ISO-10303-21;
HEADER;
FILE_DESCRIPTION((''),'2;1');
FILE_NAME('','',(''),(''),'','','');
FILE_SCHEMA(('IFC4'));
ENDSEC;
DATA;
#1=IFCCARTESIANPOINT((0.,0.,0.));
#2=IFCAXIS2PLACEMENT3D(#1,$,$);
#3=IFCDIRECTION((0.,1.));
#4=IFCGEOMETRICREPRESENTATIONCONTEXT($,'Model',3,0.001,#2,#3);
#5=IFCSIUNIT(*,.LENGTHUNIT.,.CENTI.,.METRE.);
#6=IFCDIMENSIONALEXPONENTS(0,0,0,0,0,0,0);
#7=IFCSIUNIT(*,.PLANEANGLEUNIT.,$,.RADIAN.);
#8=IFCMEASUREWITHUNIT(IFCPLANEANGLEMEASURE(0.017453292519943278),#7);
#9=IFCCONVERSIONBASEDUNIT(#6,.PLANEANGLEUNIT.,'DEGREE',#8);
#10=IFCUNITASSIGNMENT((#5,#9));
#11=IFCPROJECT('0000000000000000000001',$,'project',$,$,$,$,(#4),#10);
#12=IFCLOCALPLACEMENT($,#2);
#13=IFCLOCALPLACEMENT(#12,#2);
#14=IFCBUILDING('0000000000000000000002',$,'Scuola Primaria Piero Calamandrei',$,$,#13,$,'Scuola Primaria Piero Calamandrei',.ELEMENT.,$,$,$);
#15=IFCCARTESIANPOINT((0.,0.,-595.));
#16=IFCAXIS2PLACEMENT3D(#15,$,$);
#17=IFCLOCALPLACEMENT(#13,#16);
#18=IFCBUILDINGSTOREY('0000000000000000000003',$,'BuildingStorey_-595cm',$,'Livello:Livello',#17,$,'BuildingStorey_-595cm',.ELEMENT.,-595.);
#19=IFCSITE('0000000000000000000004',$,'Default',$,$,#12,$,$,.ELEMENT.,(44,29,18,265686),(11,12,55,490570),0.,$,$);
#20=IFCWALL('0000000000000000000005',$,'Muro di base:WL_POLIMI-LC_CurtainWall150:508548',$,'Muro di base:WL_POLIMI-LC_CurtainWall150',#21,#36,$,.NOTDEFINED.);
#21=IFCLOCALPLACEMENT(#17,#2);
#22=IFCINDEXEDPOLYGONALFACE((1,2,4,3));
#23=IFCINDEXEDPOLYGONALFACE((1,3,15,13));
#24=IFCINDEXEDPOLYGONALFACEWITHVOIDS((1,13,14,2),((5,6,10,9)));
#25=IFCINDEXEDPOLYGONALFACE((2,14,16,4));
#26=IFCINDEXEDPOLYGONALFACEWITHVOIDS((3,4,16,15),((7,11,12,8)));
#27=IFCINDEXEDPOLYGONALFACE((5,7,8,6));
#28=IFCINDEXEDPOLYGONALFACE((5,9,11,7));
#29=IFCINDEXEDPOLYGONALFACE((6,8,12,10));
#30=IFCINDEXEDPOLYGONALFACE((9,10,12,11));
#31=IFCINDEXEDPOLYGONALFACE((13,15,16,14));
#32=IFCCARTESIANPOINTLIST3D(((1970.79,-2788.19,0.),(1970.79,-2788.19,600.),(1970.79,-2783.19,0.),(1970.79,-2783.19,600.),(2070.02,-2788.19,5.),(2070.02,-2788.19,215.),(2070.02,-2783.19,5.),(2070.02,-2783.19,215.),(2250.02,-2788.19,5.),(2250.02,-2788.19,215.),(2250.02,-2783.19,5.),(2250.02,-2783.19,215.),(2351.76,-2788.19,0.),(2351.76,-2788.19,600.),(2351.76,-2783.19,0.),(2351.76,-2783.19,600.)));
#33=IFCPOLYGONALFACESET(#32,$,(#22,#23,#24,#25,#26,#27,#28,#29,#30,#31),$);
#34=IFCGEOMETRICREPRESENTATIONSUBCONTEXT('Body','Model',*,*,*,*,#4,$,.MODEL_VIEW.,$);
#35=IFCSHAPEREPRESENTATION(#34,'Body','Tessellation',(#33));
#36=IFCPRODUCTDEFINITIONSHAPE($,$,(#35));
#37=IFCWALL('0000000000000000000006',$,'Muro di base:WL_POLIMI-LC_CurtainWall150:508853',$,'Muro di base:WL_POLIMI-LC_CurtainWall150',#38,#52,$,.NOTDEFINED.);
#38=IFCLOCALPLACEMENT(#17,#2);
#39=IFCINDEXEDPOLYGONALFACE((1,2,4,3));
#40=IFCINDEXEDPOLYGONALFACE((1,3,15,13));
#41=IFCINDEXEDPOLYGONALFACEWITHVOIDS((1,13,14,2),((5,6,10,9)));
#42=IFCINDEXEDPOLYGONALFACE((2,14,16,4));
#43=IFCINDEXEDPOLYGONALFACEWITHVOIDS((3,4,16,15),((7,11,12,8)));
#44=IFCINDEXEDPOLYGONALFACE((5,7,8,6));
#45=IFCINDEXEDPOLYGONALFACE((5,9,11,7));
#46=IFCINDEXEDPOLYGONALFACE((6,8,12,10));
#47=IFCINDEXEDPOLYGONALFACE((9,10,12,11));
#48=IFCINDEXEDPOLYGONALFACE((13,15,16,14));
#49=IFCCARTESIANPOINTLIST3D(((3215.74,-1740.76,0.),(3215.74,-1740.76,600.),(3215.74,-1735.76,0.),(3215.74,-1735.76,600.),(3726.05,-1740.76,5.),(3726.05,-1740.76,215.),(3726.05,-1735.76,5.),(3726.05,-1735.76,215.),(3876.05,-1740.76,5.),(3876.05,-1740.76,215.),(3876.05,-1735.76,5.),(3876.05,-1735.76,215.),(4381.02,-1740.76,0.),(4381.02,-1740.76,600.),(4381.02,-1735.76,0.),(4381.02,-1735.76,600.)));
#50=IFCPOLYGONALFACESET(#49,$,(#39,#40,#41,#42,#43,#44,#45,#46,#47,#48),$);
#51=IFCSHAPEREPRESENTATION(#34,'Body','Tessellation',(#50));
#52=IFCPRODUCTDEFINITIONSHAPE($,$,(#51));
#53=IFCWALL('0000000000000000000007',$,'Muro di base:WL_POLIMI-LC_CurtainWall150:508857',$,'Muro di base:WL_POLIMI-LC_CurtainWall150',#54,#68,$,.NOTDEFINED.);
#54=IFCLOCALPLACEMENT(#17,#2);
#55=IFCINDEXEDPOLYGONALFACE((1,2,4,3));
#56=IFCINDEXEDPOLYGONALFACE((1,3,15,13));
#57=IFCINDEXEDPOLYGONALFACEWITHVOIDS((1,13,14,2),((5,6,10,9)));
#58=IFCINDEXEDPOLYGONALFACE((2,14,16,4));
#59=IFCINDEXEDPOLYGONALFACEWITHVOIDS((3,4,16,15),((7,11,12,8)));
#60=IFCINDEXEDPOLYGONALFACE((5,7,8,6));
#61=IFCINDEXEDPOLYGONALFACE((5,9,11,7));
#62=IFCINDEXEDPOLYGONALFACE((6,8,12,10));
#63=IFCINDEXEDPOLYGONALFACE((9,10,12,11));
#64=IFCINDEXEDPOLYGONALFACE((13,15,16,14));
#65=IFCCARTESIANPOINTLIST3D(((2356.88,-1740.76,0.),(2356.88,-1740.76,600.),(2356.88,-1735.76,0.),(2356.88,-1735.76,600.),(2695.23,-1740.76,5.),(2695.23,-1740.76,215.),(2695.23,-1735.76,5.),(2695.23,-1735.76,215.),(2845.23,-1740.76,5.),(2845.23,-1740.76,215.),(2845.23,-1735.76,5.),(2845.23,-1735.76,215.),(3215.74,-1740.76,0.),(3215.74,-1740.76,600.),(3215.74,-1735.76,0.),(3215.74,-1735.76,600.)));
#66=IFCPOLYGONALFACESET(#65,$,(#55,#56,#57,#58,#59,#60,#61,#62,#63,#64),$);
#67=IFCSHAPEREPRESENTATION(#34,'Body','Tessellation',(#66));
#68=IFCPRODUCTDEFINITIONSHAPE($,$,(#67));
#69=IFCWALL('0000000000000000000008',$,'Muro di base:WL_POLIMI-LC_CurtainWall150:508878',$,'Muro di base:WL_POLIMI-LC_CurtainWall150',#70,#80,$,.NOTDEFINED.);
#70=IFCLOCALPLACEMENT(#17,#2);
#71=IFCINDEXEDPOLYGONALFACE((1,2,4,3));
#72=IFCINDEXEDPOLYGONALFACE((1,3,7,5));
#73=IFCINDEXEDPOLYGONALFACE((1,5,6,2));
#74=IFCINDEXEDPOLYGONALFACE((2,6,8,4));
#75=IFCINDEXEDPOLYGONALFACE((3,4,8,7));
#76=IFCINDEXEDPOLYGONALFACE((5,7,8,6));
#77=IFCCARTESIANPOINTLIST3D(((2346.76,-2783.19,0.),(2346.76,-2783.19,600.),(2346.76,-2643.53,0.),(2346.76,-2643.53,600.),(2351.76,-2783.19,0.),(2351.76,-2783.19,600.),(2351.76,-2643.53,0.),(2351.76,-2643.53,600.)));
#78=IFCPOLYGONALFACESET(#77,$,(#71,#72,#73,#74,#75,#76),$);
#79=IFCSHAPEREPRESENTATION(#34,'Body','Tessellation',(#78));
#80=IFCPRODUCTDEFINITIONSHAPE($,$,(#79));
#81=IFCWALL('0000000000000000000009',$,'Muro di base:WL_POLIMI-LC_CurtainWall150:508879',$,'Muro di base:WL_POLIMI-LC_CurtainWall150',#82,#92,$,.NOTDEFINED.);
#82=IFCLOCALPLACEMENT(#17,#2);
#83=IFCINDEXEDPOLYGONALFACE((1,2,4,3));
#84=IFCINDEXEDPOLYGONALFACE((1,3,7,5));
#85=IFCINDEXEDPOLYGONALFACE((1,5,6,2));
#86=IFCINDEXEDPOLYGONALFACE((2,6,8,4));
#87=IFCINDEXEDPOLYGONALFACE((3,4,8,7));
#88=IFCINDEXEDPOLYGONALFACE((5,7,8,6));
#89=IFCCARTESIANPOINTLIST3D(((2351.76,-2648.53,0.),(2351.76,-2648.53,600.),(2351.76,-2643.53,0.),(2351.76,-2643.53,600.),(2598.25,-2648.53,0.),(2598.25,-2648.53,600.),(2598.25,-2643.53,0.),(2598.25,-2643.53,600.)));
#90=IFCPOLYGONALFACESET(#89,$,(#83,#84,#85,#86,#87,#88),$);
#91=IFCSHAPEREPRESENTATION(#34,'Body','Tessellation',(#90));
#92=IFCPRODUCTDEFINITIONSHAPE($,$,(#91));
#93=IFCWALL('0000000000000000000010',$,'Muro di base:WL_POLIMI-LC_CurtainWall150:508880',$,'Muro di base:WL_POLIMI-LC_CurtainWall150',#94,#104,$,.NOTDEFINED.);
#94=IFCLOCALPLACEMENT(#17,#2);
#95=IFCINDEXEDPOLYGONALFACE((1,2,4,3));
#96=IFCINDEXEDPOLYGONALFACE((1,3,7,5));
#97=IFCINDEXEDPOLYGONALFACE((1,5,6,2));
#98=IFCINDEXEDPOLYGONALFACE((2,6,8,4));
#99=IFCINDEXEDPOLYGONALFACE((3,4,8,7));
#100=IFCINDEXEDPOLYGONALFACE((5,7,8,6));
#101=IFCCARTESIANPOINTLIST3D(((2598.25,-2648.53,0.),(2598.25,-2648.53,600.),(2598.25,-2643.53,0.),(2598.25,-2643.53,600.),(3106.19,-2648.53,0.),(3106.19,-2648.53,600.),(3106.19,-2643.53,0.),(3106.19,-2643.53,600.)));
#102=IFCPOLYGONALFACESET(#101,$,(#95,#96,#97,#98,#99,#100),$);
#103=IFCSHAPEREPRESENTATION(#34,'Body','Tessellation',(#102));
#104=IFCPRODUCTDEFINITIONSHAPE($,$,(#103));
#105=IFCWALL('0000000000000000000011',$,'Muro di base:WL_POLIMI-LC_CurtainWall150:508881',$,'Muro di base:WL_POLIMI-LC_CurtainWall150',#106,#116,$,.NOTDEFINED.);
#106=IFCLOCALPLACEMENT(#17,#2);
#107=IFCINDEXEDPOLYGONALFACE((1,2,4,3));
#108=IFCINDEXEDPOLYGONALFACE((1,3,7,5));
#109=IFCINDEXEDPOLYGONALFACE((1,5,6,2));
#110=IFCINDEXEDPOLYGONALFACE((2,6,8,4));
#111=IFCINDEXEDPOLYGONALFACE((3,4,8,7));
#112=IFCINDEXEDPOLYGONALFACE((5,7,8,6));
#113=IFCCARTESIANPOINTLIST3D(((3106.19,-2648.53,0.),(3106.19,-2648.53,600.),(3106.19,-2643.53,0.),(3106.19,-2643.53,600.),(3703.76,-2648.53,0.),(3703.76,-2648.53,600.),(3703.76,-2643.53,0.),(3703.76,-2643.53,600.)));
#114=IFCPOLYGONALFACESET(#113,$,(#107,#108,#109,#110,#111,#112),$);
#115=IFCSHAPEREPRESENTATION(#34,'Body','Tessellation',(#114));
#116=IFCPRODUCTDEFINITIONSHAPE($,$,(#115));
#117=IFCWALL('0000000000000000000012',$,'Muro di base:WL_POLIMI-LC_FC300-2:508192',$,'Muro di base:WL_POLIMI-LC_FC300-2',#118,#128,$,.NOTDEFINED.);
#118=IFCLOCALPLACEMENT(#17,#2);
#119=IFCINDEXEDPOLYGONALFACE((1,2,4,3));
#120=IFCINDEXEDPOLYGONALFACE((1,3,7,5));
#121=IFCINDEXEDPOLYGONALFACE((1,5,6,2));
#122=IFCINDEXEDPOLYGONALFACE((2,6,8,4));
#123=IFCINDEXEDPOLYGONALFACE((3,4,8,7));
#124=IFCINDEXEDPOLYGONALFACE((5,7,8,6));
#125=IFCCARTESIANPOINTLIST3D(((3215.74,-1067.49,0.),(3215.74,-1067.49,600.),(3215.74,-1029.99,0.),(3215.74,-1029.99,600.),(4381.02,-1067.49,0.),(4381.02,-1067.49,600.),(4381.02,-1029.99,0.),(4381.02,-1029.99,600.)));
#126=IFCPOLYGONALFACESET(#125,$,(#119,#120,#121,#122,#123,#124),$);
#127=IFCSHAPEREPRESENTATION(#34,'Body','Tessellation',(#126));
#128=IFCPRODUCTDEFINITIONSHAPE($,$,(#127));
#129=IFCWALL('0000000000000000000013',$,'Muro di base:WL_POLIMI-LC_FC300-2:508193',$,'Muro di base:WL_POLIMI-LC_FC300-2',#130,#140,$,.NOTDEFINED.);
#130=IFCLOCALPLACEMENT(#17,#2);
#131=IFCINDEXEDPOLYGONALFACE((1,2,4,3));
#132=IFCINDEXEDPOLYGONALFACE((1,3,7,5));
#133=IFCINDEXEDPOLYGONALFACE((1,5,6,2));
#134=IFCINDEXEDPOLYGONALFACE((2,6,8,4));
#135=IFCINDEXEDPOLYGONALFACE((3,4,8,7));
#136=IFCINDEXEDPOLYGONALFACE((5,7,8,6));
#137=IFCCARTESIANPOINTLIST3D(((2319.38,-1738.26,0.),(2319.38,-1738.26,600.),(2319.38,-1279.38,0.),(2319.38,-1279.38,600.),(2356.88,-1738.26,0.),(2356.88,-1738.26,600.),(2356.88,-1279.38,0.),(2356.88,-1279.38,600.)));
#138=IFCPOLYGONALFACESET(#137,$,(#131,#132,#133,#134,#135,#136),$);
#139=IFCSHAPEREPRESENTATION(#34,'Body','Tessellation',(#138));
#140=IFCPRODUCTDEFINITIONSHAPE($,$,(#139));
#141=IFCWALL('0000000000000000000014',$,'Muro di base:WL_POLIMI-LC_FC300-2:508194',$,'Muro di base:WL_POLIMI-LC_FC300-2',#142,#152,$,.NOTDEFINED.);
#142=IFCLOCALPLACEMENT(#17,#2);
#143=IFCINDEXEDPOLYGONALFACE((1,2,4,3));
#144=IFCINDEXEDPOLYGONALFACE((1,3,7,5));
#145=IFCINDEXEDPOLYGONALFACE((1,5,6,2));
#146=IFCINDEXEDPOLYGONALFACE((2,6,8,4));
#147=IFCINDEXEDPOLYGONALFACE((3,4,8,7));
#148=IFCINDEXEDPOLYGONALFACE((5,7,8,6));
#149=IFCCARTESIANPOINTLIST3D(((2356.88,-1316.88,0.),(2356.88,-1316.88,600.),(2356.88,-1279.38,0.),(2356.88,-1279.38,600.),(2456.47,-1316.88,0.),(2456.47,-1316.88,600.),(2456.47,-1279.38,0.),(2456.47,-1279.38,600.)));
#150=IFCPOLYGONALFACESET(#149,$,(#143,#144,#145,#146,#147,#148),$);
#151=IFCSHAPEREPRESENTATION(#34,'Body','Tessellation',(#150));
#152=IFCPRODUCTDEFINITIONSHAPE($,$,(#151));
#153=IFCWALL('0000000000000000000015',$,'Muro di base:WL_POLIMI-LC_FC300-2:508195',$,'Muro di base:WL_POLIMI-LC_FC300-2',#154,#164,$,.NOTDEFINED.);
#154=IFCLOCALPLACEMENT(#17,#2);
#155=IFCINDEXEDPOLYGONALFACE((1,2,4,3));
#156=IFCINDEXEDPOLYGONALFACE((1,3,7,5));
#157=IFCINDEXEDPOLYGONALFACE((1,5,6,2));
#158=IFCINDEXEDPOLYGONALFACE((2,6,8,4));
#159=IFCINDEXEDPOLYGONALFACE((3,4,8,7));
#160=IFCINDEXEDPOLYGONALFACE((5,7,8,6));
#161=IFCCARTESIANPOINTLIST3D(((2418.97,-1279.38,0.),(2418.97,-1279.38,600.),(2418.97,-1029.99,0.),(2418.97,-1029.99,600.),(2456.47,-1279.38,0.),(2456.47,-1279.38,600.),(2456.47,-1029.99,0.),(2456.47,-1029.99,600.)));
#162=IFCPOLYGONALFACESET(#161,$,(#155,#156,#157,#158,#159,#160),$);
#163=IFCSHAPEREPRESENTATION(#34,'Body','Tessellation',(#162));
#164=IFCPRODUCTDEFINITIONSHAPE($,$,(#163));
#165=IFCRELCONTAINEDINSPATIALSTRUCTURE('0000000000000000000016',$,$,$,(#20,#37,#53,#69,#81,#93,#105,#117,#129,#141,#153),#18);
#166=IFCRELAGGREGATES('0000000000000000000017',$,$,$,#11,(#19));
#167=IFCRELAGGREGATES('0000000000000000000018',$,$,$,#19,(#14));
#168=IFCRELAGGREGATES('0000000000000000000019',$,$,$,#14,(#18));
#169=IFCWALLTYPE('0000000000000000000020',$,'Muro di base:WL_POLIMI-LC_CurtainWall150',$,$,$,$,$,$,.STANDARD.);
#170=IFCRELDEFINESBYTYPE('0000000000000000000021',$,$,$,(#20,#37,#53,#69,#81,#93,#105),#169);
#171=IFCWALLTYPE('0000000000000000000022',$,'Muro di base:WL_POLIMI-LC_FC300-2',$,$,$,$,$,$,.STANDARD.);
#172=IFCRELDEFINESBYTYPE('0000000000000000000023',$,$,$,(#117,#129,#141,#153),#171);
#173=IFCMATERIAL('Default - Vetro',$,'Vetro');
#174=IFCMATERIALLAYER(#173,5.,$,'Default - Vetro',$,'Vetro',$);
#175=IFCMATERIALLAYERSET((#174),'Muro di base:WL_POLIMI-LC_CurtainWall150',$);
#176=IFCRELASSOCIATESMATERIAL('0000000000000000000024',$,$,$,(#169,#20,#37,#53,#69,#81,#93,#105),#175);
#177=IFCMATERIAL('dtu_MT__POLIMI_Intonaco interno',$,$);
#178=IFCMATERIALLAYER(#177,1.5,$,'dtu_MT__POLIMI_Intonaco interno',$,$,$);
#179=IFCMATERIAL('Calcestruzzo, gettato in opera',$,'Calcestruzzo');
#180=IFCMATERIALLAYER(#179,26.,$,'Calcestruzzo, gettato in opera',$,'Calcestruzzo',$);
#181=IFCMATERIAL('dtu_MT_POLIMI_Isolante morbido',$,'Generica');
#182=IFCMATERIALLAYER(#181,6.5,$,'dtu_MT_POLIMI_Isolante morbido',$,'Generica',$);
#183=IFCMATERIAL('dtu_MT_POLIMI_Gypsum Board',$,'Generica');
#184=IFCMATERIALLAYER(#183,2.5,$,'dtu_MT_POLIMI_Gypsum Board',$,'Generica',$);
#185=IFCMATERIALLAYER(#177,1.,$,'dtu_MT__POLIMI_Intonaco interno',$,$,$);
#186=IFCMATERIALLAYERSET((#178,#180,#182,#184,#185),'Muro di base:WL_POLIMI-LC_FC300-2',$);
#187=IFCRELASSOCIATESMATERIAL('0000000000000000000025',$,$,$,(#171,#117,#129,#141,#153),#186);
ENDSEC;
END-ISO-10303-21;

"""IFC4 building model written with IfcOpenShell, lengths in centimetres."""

from ifc_helpers import new_model, entity, si_unit, converted_unit, direction, frame, frame_2d, origin, place, context, subcontext, project, spatial, rectangle, extrude, material, layer, layer_set, layer_usage, type_object, element, save


model = new_model("IFC4")

# Units and contexts
model_context = context("Model", 3, precision=0.001, world=origin(), true_north=direction((0.0, 1.0)))
body_context = subcontext(model_context, "Body", "Model", "MODEL_VIEW")
ifc_project = project(units=[si_unit("LENGTHUNIT", "METRE", prefix="CENTI"), converted_unit("PLANEANGLEUNIT", "DEGREE", entity("IfcPlaneAngleMeasure", 0.017453292519943278), si_unit("PLANEANGLEUNIT", "RADIAN"), dimensions=[0, 0, 0, 0, 0, 0, 0])], contexts=[model_context])

# Site, building, storey
site_placement = place(None, origin())
site = spatial("IfcSite", under=ifc_project, at=site_placement, Name="Default", CompositionType="ELEMENT", RefLatitude=(44, 29, 18, 265686), RefLongitude=(11, 12, 55, 490570), RefElevation=0.0)
building_placement = place(site_placement, origin())
building = spatial("IfcBuilding", under=site, at=building_placement, Name="Scuola Primaria Piero Calamandrei", LongName="Scuola Primaria Piero Calamandrei", CompositionType="ELEMENT")
storey_placement = place(building_placement, frame((0.0, 0.0, -595.0)))
storey = spatial("IfcBuildingStorey", under=building, at=storey_placement, Name="BuildingStorey_-595cm", ObjectType="Livello:Livello", LongName="BuildingStorey_-595cm", CompositionType="ELEMENT", Elevation=-595.0)

# Wall, opening
ifc_material_1 = material(Name="Default - Vetro", Category="Vetro")
ifc_layer_1 = layer(ifc_material_1, 5.0, Name="Default - Vetro", Category="Vetro")
ifc_layer_set_1 = layer_set([ifc_layer_1], Name="Muro di base:WL_POLIMI-LC_CurtainWall150")
ifc_layer_usage_1 = layer_usage(ifc_layer_set_1, "AXIS2", "NEGATIVE", 2.5)
wall_type_1 = type_object("IfcWallType", Name="Muro di base:WL_POLIMI-LC_CurtainWall150", PredefinedType="STANDARD", material=ifc_layer_set_1)
wall_1_placement = place(storey_placement, frame((1970.79, -2785.69, 0.0)))
wall_1 = element("IfcWall", 1, at=wall_1_placement, inside=storey, type_object=wall_type_1, material=ifc_layer_usage_1, Name="Muro di base:WL_POLIMI-LC_CurtainWall150:508548", ObjectType="Muro di base:WL_POLIMI-LC_CurtainWall150", PredefinedType="NOTDEFINED", context=body_context, shape_type="SweptSolid", body=[
    extrude(rectangle(XDim=380.97, YDim=5.0, at=frame_2d((190.48, 0.0), x_axis=(-1.0, 0.0))), origin(), (0.0, 0.0, 1.0), 600.0),
])
opening_1_placement = place(wall_1_placement, frame((99.23, -2.5, 5.0)))
element("IfcOpeningElement", 2, at=opening_1_placement, cuts=wall_1, PredefinedType="OPENING", context=body_context, shape_type="SweptSolid", body=[
    extrude(rectangle(XDim=210.0, YDim=180.0, at=frame_2d((105.0, 90.0), x_axis=(-1.0, 0.0))), frame((0.0, 0.0, 0.0), z_axis=(0.0, 1.0, 0.0), x_axis=(0.0, 0.0, 1.0)), (0.0, 0.0, 1.0), 5.0),
])

# Walls, openings
ifc_layer_usage_2 = layer_usage(ifc_layer_set_1, "AXIS2", "NEGATIVE", 2.5)
wall_2_placement = place(storey_placement, frame((3215.74, -1738.26, 0.0)))
wall_2 = element("IfcWall", 3, at=wall_2_placement, inside=storey, type_object=wall_type_1, material=ifc_layer_usage_2, Name="Muro di base:WL_POLIMI-LC_CurtainWall150:508853", ObjectType="Muro di base:WL_POLIMI-LC_CurtainWall150", PredefinedType="NOTDEFINED", context=body_context, shape_type="SweptSolid", body=[
    extrude(rectangle(XDim=1165.28, YDim=5.0, at=frame_2d((582.64, 0.0), x_axis=(-1.0, 0.0))), origin(), (0.0, 0.0, 1.0), 600.0),
])
opening_2_placement = place(wall_2_placement, frame((660.31, 2.5, 5.0)))
element("IfcOpeningElement", 4, at=opening_2_placement, cuts=wall_2, PredefinedType="OPENING", context=body_context, shape_type="SweptSolid", body=[
    extrude(rectangle(XDim=210.0, YDim=150.0, at=frame_2d((105.0, 75.0), x_axis=(-1.0, 0.0))), frame((0.0, 0.0, 0.0), z_axis=(0.0, -1.0, 0.0), x_axis=(0.0, 0.0, 1.0)), (0.0, 0.0, 1.0), 5.0),
])
ifc_layer_usage_3 = layer_usage(ifc_layer_set_1, "AXIS2", "NEGATIVE", 2.5)
wall_3_placement = place(storey_placement, frame((2356.88, -1738.26, 0.0)))
wall_3 = element("IfcWall", 5, at=wall_3_placement, inside=storey, type_object=wall_type_1, material=ifc_layer_usage_3, Name="Muro di base:WL_POLIMI-LC_CurtainWall150:508857", ObjectType="Muro di base:WL_POLIMI-LC_CurtainWall150", PredefinedType="NOTDEFINED", context=body_context, shape_type="SweptSolid", body=[
    extrude(rectangle(XDim=858.87, YDim=5.0, at=frame_2d((429.43, 0.0), x_axis=(-1.0, 0.0))), origin(), (0.0, 0.0, 1.0), 600.0),
])
opening_3_placement = place(wall_3_placement, frame((488.36, 2.5, 5.0)))
element("IfcOpeningElement", 6, at=opening_3_placement, cuts=wall_3, PredefinedType="OPENING", context=body_context, shape_type="SweptSolid", body=[
    extrude(rectangle(XDim=210.0, YDim=150.0, at=frame_2d((105.0, 75.0), x_axis=(-1.0, 0.0))), frame((0.0, 0.0, 0.0), z_axis=(0.0, -1.0, 0.0), x_axis=(0.0, 0.0, 1.0)), (0.0, 0.0, 1.0), 5.0),
])

# Walls
ifc_layer_usage_4 = layer_usage(ifc_layer_set_1, "AXIS2", "NEGATIVE", 2.5)
wall_4_placement = place(storey_placement, frame((2349.26, -2643.53, 0.0), z_axis=(0.0, 0.0, 1.0), x_axis=(0.0, -1.0, 0.0)))
element("IfcWall", 7, at=wall_4_placement, inside=storey, type_object=wall_type_1, material=ifc_layer_usage_4, Name="Muro di base:WL_POLIMI-LC_CurtainWall150:508878", ObjectType="Muro di base:WL_POLIMI-LC_CurtainWall150", PredefinedType="NOTDEFINED", context=body_context, shape_type="SweptSolid", body=[
    extrude(rectangle(XDim=139.66, YDim=5.0, at=frame_2d((69.83, 0.0), x_axis=(-1.0, 0.0))), origin(), (0.0, 0.0, 1.0), 600.0),
])
ifc_layer_usage_5 = layer_usage(ifc_layer_set_1, "AXIS2", "NEGATIVE", 2.5)
wall_5_placement = place(storey_placement, frame((2598.25, -2646.03, 0.0), z_axis=(0.0, 0.0, 1.0), x_axis=(-1.0, 0.0, 0.0)))
element("IfcWall", 8, at=wall_5_placement, inside=storey, type_object=wall_type_1, material=ifc_layer_usage_5, Name="Muro di base:WL_POLIMI-LC_CurtainWall150:508879", ObjectType="Muro di base:WL_POLIMI-LC_CurtainWall150", PredefinedType="NOTDEFINED", context=body_context, shape_type="SweptSolid", body=[
    extrude(rectangle(XDim=246.49, YDim=5.0, at=frame_2d((123.25, 0.0), x_axis=(-1.0, 0.0))), origin(), (0.0, 0.0, 1.0), 600.0),
])
ifc_layer_usage_6 = layer_usage(ifc_layer_set_1, "AXIS2", "NEGATIVE", 2.5)
wall_6_placement = place(storey_placement, frame((3106.19, -2646.03, 0.0), z_axis=(0.0, 0.0, 1.0), x_axis=(-1.0, 0.0, 0.0)))
element("IfcWall", 9, at=wall_6_placement, inside=storey, type_object=wall_type_1, material=ifc_layer_usage_6, Name="Muro di base:WL_POLIMI-LC_CurtainWall150:508880", ObjectType="Muro di base:WL_POLIMI-LC_CurtainWall150", PredefinedType="NOTDEFINED", context=body_context, shape_type="SweptSolid", body=[
    extrude(rectangle(XDim=507.94, YDim=5.0, at=frame_2d((253.97, 0.0), x_axis=(-1.0, 0.0))), origin(), (0.0, 0.0, 1.0), 600.0),
])
ifc_layer_usage_7 = layer_usage(ifc_layer_set_1, "AXIS2", "NEGATIVE", 2.5)
wall_7_placement = place(storey_placement, frame((3703.76, -2646.03, 0.0), z_axis=(0.0, 0.0, 1.0), x_axis=(-1.0, 0.0, 0.0)))
element("IfcWall", 10, at=wall_7_placement, inside=storey, type_object=wall_type_1, material=ifc_layer_usage_7, Name="Muro di base:WL_POLIMI-LC_CurtainWall150:508881", ObjectType="Muro di base:WL_POLIMI-LC_CurtainWall150", PredefinedType="NOTDEFINED", context=body_context, shape_type="SweptSolid", body=[
    extrude(rectangle(XDim=597.58, YDim=5.0, at=frame_2d((298.79, 0.0), x_axis=(-1.0, 0.0))), origin(), (0.0, 0.0, 1.0), 600.0),
])
ifc_material_2 = material(Name="dtu_MT__POLIMI_Intonaco interno")
ifc_layer_2 = layer(ifc_material_2, 1.5, Name="dtu_MT__POLIMI_Intonaco interno")
ifc_material_3 = material(Name="Calcestruzzo, gettato in opera", Category="Calcestruzzo")
ifc_layer_3 = layer(ifc_material_3, 26.0, Name="Calcestruzzo, gettato in opera", Category="Calcestruzzo")
ifc_material_4 = material(Name="dtu_MT_POLIMI_Isolante morbido", Category="Generica")
ifc_layer_4 = layer(ifc_material_4, 6.5, Name="dtu_MT_POLIMI_Isolante morbido", Category="Generica")
ifc_material_5 = material(Name="dtu_MT_POLIMI_Gypsum Board", Category="Generica")
ifc_layer_5 = layer(ifc_material_5, 2.5, Name="dtu_MT_POLIMI_Gypsum Board", Category="Generica")
ifc_layer_6 = layer(ifc_material_2, 1.0, Name="dtu_MT__POLIMI_Intonaco interno")
ifc_layer_set_2 = layer_set([ifc_layer_2, ifc_layer_3, ifc_layer_4, ifc_layer_5, ifc_layer_6], Name="Muro di base:WL_POLIMI-LC_FC300-2")
ifc_layer_usage_8 = layer_usage(ifc_layer_set_2, "AXIS2", "NEGATIVE", 18.75)
wall_type_2 = type_object("IfcWallType", Name="Muro di base:WL_POLIMI-LC_FC300-2", PredefinedType="STANDARD", material=ifc_layer_set_2)
wall_8_placement = place(storey_placement, frame((3215.74, -1048.74, 0.0)))
element("IfcWall", 11, at=wall_8_placement, inside=storey, type_object=wall_type_2, material=ifc_layer_usage_8, Name="Muro di base:WL_POLIMI-LC_FC300-2:508192", ObjectType="Muro di base:WL_POLIMI-LC_FC300-2", PredefinedType="NOTDEFINED", context=body_context, shape_type="SweptSolid", body=[
    extrude(rectangle(XDim=1165.28, YDim=37.5, at=frame_2d((582.64, 0.0), x_axis=(-1.0, 0.0))), origin(), (0.0, 0.0, 1.0), 600.0),
])
ifc_layer_usage_9 = layer_usage(ifc_layer_set_2, "AXIS2", "NEGATIVE", 18.75)
wall_9_placement = place(storey_placement, frame((2338.13, -1738.26, 0.0), z_axis=(0.0, 0.0, 1.0), x_axis=(0.0, 1.0, 0.0)))
element("IfcWall", 12, at=wall_9_placement, inside=storey, type_object=wall_type_2, material=ifc_layer_usage_9, Name="Muro di base:WL_POLIMI-LC_FC300-2:508193", ObjectType="Muro di base:WL_POLIMI-LC_FC300-2", PredefinedType="NOTDEFINED", context=body_context, shape_type="SweptSolid", body=[
    extrude(rectangle(XDim=458.88, YDim=37.5, at=frame_2d((229.44, 0.0), x_axis=(-1.0, 0.0))), origin(), (0.0, 0.0, 1.0), 600.0),
])
ifc_layer_usage_10 = layer_usage(ifc_layer_set_2, "AXIS2", "NEGATIVE", 18.75)
wall_10_placement = place(storey_placement, frame((2356.88, -1298.13, 0.0)))
element("IfcWall", 13, at=wall_10_placement, inside=storey, type_object=wall_type_2, material=ifc_layer_usage_10, Name="Muro di base:WL_POLIMI-LC_FC300-2:508194", ObjectType="Muro di base:WL_POLIMI-LC_FC300-2", PredefinedType="NOTDEFINED", context=body_context, shape_type="SweptSolid", body=[
    extrude(rectangle(XDim=99.6, YDim=37.5, at=frame_2d((49.8, 0.0), x_axis=(-1.0, 0.0))), origin(), (0.0, 0.0, 1.0), 600.0),
])
ifc_layer_usage_11 = layer_usage(ifc_layer_set_2, "AXIS2", "NEGATIVE", 18.75)
wall_11_placement = place(storey_placement, frame((2437.72, -1279.38, 0.0), z_axis=(0.0, 0.0, 1.0), x_axis=(0.0, 1.0, 0.0)))
element("IfcWall", 14, at=wall_11_placement, inside=storey, type_object=wall_type_2, material=ifc_layer_usage_11, Name="Muro di base:WL_POLIMI-LC_FC300-2:508195", ObjectType="Muro di base:WL_POLIMI-LC_FC300-2", PredefinedType="NOTDEFINED", context=body_context, shape_type="SweptSolid", body=[
    extrude(rectangle(XDim=249.39, YDim=37.5, at=frame_2d((124.69, 0.0), x_axis=(-1.0, 0.0))), origin(), (0.0, 0.0, 1.0), 600.0),
])

save(model, "model.ifc")
